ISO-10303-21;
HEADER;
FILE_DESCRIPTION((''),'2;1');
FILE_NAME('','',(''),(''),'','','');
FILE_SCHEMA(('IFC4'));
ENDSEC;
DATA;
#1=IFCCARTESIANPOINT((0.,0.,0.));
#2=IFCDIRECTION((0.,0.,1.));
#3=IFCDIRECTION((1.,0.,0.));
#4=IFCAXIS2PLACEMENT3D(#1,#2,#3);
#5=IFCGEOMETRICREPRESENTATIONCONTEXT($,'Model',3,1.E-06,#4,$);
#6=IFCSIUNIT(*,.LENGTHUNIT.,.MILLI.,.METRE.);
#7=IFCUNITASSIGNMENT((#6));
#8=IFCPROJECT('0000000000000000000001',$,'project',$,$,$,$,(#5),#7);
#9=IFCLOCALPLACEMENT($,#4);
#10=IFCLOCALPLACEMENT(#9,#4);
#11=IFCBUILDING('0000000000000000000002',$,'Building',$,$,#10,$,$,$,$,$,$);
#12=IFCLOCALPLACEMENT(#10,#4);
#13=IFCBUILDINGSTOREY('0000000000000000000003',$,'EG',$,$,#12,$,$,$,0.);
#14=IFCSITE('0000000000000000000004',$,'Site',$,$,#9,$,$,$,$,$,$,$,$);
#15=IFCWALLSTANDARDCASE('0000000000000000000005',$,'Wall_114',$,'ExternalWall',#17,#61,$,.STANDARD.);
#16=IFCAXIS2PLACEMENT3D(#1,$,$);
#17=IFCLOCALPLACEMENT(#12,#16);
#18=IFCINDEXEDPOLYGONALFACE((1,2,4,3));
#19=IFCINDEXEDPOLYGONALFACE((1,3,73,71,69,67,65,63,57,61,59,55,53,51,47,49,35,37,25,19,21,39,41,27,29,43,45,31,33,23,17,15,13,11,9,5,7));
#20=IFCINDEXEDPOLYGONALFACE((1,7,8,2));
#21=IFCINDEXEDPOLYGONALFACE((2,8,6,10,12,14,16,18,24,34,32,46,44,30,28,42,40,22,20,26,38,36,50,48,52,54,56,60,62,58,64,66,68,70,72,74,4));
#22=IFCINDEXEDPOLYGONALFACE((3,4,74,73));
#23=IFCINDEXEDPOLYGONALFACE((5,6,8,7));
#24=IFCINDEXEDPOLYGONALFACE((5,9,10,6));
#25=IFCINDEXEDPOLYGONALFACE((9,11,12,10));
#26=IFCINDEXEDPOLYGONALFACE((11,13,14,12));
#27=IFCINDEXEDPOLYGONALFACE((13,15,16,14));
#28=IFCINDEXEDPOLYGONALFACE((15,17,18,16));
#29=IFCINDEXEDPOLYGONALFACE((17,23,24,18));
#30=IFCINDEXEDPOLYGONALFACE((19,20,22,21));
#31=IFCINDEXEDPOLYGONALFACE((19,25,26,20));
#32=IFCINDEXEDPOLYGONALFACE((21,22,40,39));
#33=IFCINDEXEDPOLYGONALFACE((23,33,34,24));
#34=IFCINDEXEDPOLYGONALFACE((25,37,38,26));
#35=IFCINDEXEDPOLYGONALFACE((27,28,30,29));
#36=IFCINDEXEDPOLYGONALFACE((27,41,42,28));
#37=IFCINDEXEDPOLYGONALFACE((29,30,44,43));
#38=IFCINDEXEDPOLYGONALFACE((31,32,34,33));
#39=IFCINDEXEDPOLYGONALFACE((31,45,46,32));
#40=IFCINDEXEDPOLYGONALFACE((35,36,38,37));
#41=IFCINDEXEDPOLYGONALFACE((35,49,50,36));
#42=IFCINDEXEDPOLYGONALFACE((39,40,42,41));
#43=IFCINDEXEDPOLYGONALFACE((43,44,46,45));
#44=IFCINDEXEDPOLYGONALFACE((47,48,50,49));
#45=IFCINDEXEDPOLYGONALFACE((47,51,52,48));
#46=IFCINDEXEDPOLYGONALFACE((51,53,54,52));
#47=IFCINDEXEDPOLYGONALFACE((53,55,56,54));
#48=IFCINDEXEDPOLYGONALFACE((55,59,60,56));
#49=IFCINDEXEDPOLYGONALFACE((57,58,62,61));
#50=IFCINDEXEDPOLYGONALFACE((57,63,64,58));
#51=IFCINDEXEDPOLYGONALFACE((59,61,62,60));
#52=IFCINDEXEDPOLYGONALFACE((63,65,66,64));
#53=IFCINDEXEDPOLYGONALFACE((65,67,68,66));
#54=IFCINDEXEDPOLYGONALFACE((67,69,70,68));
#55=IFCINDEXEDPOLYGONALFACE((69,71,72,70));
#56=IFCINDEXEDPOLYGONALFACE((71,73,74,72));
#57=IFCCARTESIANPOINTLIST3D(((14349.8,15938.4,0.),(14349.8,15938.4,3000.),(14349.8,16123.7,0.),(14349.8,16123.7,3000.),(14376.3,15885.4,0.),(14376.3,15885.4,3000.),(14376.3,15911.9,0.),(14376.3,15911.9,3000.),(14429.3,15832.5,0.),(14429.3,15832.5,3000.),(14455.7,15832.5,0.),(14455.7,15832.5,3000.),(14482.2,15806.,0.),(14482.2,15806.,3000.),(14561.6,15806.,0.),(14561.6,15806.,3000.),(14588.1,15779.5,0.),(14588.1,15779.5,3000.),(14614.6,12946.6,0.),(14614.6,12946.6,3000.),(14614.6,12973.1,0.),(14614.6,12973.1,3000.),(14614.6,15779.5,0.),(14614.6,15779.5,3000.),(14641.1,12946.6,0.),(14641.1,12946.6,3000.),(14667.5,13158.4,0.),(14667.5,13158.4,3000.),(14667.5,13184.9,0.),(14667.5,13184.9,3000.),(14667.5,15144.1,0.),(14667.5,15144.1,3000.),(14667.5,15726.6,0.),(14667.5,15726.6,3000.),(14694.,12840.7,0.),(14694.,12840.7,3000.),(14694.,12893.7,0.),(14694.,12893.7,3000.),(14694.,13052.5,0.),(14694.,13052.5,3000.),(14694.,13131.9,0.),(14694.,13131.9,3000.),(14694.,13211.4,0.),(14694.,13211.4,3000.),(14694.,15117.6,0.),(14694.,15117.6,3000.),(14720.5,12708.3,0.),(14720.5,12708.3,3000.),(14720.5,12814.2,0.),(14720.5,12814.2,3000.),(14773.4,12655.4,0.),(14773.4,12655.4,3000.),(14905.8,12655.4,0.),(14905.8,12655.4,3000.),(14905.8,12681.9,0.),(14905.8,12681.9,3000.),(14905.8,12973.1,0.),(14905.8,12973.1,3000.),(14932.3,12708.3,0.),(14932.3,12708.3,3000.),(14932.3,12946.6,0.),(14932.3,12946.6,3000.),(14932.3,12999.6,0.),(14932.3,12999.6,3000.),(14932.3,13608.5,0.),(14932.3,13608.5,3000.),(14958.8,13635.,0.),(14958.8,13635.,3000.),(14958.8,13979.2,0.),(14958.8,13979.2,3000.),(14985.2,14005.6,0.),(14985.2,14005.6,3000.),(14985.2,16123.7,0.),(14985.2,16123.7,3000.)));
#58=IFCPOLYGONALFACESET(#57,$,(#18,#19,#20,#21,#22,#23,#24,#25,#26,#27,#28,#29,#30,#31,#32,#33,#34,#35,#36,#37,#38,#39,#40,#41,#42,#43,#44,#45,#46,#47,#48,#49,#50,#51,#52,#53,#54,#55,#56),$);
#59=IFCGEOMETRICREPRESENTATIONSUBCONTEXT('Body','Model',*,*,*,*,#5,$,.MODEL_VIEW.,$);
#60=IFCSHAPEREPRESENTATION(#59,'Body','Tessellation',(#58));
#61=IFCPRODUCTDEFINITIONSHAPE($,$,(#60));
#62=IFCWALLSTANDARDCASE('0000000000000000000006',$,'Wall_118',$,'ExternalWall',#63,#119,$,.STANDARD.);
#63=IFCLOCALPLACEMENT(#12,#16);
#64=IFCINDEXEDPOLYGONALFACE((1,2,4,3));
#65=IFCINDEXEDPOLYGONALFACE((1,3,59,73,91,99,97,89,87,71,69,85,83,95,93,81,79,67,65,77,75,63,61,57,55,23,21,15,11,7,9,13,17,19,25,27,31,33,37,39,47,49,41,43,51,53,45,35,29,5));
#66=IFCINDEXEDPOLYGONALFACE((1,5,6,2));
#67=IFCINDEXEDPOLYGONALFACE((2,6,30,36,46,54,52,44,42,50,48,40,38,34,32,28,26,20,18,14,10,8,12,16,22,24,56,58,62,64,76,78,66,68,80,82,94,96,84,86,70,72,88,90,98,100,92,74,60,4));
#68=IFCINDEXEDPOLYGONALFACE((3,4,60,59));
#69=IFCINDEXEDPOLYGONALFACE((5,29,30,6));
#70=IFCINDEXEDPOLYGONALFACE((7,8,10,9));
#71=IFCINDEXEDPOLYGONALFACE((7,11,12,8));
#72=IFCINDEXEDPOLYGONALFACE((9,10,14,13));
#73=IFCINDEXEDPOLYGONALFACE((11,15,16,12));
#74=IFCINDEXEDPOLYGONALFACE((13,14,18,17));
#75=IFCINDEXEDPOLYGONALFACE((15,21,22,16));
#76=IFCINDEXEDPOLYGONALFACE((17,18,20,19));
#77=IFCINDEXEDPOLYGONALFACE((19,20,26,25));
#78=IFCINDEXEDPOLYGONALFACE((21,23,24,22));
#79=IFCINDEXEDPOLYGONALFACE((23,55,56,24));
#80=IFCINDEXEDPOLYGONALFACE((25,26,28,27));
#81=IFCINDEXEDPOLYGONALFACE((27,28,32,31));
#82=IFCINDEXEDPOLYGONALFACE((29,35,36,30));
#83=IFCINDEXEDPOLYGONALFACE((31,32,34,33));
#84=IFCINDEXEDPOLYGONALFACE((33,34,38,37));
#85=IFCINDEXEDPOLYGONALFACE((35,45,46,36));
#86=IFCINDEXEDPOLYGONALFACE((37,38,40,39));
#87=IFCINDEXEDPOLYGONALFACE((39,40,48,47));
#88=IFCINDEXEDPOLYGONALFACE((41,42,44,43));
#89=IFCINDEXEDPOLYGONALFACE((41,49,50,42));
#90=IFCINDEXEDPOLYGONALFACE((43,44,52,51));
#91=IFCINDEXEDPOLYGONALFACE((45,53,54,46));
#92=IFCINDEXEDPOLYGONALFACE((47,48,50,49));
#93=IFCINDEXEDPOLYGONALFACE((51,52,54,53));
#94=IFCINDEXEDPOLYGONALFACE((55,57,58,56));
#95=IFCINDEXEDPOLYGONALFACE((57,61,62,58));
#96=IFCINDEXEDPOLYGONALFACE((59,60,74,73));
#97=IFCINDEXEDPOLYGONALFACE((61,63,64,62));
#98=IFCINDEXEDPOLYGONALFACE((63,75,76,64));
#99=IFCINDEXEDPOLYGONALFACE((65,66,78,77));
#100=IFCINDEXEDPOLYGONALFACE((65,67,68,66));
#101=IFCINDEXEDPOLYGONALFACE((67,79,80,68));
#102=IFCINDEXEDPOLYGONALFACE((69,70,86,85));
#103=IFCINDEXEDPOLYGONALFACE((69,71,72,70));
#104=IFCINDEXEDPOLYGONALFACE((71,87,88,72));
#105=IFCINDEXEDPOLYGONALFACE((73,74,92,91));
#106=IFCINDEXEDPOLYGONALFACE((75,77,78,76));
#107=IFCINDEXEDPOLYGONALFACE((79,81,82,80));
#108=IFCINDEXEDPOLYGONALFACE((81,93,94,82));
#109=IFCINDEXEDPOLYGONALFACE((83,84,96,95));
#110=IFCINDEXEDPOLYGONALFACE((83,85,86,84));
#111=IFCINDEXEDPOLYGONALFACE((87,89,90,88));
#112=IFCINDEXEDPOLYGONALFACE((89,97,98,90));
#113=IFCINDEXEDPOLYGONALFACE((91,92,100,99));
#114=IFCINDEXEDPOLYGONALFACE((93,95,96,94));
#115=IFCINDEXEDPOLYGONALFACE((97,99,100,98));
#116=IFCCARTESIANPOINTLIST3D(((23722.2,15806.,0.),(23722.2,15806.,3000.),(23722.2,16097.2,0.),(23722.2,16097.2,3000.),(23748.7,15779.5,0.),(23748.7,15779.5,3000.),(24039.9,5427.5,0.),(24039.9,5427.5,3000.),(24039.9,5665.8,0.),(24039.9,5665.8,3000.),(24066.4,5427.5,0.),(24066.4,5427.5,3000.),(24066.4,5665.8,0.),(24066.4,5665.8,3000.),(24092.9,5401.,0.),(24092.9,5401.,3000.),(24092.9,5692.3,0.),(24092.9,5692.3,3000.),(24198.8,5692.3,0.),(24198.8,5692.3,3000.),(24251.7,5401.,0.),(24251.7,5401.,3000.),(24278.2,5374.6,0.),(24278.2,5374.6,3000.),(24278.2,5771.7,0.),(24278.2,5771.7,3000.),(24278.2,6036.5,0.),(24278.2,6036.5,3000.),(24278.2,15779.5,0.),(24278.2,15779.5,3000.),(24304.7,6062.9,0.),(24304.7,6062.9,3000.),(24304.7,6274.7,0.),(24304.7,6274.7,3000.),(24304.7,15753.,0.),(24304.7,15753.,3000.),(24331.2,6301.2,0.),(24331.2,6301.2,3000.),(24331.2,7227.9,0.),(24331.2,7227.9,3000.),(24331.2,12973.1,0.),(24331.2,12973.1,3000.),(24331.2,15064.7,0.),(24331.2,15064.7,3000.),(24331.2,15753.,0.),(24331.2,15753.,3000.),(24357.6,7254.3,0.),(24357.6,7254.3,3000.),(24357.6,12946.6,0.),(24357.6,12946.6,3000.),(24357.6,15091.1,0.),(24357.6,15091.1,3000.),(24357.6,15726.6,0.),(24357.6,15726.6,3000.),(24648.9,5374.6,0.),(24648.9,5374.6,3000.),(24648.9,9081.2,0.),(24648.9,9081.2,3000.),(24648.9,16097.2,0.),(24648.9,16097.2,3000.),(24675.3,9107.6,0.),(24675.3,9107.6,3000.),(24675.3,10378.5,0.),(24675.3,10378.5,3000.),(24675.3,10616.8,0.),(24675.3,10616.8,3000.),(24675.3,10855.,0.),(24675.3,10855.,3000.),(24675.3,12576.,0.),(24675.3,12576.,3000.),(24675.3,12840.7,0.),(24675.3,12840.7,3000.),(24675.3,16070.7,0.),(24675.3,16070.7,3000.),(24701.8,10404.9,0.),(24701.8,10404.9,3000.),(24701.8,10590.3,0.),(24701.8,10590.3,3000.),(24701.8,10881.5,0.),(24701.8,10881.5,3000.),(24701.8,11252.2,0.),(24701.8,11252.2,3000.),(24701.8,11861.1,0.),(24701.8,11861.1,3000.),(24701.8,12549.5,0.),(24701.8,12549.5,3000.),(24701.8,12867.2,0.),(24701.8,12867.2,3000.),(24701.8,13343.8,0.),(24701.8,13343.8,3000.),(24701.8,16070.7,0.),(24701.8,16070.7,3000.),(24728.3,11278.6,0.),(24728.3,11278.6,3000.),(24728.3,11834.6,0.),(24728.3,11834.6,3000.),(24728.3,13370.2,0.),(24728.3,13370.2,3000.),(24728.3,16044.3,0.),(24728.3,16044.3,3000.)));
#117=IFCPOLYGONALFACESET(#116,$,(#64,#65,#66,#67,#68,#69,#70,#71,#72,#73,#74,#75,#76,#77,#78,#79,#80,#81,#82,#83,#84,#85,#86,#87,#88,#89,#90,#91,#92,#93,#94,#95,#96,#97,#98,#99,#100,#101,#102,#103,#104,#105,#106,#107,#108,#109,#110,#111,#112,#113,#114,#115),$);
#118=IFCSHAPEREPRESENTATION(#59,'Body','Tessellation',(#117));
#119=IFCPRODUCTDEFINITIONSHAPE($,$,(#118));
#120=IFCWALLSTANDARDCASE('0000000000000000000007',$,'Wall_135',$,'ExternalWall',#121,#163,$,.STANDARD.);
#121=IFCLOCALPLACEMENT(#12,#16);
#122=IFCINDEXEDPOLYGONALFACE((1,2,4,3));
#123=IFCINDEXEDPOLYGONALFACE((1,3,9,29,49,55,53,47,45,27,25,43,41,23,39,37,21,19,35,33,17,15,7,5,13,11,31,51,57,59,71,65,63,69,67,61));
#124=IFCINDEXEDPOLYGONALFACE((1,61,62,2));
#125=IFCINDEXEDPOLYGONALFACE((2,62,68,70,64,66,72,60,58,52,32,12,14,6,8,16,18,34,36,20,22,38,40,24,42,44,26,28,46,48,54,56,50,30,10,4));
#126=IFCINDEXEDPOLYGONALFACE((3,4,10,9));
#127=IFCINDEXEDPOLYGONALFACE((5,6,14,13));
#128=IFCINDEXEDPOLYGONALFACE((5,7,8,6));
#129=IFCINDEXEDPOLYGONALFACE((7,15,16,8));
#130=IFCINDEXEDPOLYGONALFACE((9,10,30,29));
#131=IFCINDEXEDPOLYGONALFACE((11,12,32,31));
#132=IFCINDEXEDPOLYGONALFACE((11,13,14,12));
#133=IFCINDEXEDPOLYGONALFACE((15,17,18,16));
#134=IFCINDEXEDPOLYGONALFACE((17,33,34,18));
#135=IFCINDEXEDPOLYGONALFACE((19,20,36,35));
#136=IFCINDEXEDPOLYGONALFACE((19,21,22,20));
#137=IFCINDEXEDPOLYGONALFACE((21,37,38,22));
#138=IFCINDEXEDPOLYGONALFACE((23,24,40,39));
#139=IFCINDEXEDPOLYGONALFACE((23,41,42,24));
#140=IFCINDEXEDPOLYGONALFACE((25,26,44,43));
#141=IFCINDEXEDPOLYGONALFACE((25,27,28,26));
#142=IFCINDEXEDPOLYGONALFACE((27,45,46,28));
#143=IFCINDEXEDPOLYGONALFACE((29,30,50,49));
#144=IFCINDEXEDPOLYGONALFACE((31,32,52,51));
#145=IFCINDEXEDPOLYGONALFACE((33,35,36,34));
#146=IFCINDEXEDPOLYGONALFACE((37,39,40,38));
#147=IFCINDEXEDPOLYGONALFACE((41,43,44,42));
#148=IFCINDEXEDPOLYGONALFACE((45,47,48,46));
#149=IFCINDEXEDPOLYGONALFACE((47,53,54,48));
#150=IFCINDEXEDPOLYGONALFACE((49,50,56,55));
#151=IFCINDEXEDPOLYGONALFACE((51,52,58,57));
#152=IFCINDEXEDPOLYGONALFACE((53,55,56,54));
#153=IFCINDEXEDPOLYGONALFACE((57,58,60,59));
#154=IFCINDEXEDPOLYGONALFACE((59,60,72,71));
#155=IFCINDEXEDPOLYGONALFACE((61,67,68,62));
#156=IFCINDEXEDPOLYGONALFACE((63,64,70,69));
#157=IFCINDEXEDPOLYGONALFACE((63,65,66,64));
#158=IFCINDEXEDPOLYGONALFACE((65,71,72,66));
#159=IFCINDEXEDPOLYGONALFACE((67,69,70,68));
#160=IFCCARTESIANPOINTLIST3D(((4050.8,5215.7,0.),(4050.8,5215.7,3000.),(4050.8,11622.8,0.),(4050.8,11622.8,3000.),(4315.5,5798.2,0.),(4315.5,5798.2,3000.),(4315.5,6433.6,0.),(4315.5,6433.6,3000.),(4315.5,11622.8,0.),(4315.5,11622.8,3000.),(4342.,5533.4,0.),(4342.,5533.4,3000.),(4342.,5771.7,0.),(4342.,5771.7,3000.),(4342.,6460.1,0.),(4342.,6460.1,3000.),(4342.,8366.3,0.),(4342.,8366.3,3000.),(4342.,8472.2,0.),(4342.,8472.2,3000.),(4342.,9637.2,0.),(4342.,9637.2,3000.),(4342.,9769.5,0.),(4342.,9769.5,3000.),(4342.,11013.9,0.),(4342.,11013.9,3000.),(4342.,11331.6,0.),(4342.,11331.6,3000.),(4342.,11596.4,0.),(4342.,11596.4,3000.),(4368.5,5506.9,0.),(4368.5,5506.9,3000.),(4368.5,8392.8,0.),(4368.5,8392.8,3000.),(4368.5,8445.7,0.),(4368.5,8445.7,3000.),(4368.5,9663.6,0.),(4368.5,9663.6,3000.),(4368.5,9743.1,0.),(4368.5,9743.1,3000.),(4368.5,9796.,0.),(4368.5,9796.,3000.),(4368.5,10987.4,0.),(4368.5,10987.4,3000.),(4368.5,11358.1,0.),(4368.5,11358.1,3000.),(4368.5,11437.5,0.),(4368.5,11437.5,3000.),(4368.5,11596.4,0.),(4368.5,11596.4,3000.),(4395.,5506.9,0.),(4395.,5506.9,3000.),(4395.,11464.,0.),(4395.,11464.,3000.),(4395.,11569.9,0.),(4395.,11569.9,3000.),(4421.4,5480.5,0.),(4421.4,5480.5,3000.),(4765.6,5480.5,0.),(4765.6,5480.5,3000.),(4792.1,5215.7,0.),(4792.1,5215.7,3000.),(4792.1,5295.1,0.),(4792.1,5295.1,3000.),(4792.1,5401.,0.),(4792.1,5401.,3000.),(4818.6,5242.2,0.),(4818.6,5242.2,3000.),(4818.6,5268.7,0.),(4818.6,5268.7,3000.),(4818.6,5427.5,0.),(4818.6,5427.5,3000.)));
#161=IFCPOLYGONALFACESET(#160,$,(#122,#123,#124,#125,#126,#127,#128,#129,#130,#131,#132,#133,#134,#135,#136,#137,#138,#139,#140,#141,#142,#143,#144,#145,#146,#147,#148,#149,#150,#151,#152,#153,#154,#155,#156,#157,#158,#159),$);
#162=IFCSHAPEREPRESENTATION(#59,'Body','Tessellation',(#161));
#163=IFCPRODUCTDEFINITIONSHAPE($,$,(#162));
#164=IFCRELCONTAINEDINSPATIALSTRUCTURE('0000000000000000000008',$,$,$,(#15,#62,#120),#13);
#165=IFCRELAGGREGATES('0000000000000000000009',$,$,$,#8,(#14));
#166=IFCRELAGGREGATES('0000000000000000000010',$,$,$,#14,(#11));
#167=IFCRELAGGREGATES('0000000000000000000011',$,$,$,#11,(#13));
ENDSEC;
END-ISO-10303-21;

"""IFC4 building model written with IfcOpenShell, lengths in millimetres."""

from ifc_helpers import new_model, si_unit, frame, origin_with_axes, place, context, subcontext, project, spatial, polyline, outline, extrude, element, save


model = new_model("IFC4")

# Units and contexts
model_context = context("Model", 3, precision=1e-06, world=origin_with_axes())
body_context = subcontext(model_context, "Body", "Model", "MODEL_VIEW")
ifc_project = project(units=[si_unit("LENGTHUNIT", "METRE", prefix="MILLI")], contexts=[model_context])

# Site, building, storey
site_placement = place(None, origin_with_axes())
site = spatial("IfcSite", under=ifc_project, at=site_placement, Name="Site")
building_placement = place(site_placement, origin_with_axes())
building = spatial("IfcBuilding", under=site, at=building_placement, Name="Building")
storey_placement = place(building_placement, origin_with_axes())
storey = spatial("IfcBuildingStorey", under=building, at=storey_placement, Name="EG", Elevation=0.0)

# Walls
for number, where, z_axis, x_axis, name in (
    (1, (0.0, 0.0, 0.0), (0.0, 0.0, 1.0), (1.0, 0.0, 0.0), "Wall_114"),
):
    element("IfcWallStandardCase", number, at=place(storey_placement, frame(where, z_axis=z_axis, x_axis=x_axis)), inside=storey, Name=name, ObjectType="ExternalWall", PredefinedType="STANDARD", context=body_context, shape_type="SweptSolid", body=[
        extrude(outline(polyline([(14773.4, 12655.4, 0.0), (14720.5, 12708.3, 0.0), (14720.5, 12814.2, 0.0), (14694.0, 12840.7, 0.0), (14694.0, 12893.7, 0.0), (14641.1, 12946.6, 0.0), (14614.6, 12946.6, 0.0), (14614.6, 12973.1, 0.0), (14694.0, 13052.5, 0.0), (14694.0, 13131.9, 0.0), (14667.5, 13158.4, 0.0), (14667.5, 13184.9, 0.0), (14694.0, 13211.4, 0.0), (14694.0, 15117.6, 0.0), (14667.5, 15144.1, 0.0), (14667.5, 15726.6, 0.0), (14614.6, 15779.5, 0.0), (14588.1, 15779.5, 0.0), (14561.6, 15806.0, 0.0), (14482.2, 15806.0, 0.0), (14455.7, 15832.5, 0.0), (14429.3, 15832.5, 0.0), (14376.3, 15885.4, 0.0), (14376.3, 15911.9, 0.0), (14349.8, 15938.4, 0.0), (14349.8, 16123.7, 0.0), (14985.2, 16123.7, 0.0), (14985.2, 14005.6, 0.0), (14958.8, 13979.2, 0.0), (14958.8, 13635.0, 0.0), (14932.3, 13608.5, 0.0), (14932.3, 12999.6, 0.0), (14905.8, 12973.1, 0.0), (14932.3, 12946.6, 0.0), (14932.3, 12708.3, 0.0), (14905.8, 12681.9, 0.0), (14905.8, 12655.4, 0.0), (14773.4, 12655.4, 0.0)])), origin_with_axes(), (0.0, 0.0, 1.0), 3000.0),
    ])
wall_1_placement = place(storey_placement, origin_with_axes())
element("IfcWallStandardCase", 2, at=wall_1_placement, inside=storey, Name="Wall_118", ObjectType="ExternalWall", PredefinedType="STANDARD", context=body_context, shape_type="SweptSolid", body=[
    extrude(outline(polyline([(24278.2, 5374.6, 0.0), (24251.7, 5401.0, 0.0), (24092.9, 5401.0, 0.0), (24066.4, 5427.5, 0.0), (24039.9, 5427.5, 0.0), (24039.9, 5665.8, 0.0), (24066.4, 5665.8, 0.0), (24092.9, 5692.3, 0.0), (24198.8, 5692.3, 0.0), (24278.2, 5771.7, 0.0), (24278.2, 6036.5, 0.0), (24304.7, 6062.9, 0.0), (24304.7, 6274.7, 0.0), (24331.2, 6301.2, 0.0), (24331.2, 7227.9, 0.0), (24357.6, 7254.3, 0.0), (24357.6, 12946.6, 0.0), (24331.2, 12973.1, 0.0), (24331.2, 15064.7, 0.0), (24357.6, 15091.1, 0.0), (24357.6, 15726.6, 0.0), (24331.2, 15753.0, 0.0), (24304.7, 15753.0, 0.0), (24278.2, 15779.5, 0.0), (23748.7, 15779.5, 0.0), (23722.2, 15806.0, 0.0), (23722.2, 16097.2, 0.0), (24648.9, 16097.2, 0.0), (24675.3, 16070.7, 0.0), (24701.8, 16070.7, 0.0), (24728.3, 16044.3, 0.0), (24728.3, 13370.2, 0.0), (24701.8, 13343.8, 0.0), (24701.8, 12867.2, 0.0), (24675.3, 12840.7, 0.0), (24675.3, 12576.0, 0.0), (24701.8, 12549.5, 0.0), (24701.8, 11861.1, 0.0), (24728.3, 11834.6, 0.0), (24728.3, 11278.6, 0.0), (24701.8, 11252.2, 0.0), (24701.8, 10881.5, 0.0), (24675.3, 10855.0, 0.0), (24675.3, 10616.8, 0.0), (24701.8, 10590.3, 0.0), (24701.8, 10404.9, 0.0), (24675.3, 10378.5, 0.0), (24675.3, 9107.6, 0.0), (24648.9, 9081.2, 0.0), (24648.9, 5374.6, 0.0), (24278.2, 5374.6, 0.0)])), origin_with_axes(), (0.0, 0.0, 1.0), 3000.0),
])
for number, where, z_axis, x_axis, name in (
    (3, (0.0, 0.0, 0.0), (0.0, 0.0, 1.0), (1.0, 0.0, 0.0), "Wall_135"),
):
    element("IfcWallStandardCase", number, at=place(storey_placement, frame(where, z_axis=z_axis, x_axis=x_axis)), inside=storey, Name=name, ObjectType="ExternalWall", PredefinedType="STANDARD", context=body_context, shape_type="SweptSolid", body=[
        extrude(outline(polyline([(4050.8, 5215.7, 0.0), (4050.8, 11622.8, 0.0), (4315.5, 11622.8, 0.0), (4342.0, 11596.4, 0.0), (4368.5, 11596.4, 0.0), (4395.0, 11569.9, 0.0), (4395.0, 11464.0, 0.0), (4368.5, 11437.5, 0.0), (4368.5, 11358.1, 0.0), (4342.0, 11331.6, 0.0), (4342.0, 11013.9, 0.0), (4368.5, 10987.4, 0.0), (4368.5, 9796.0, 0.0), (4342.0, 9769.5, 0.0), (4368.5, 9743.1, 0.0), (4368.5, 9663.6, 0.0), (4342.0, 9637.2, 0.0), (4342.0, 8472.2, 0.0), (4368.5, 8445.7, 0.0), (4368.5, 8392.8, 0.0), (4342.0, 8366.3, 0.0), (4342.0, 6460.1, 0.0), (4315.5, 6433.6, 0.0), (4315.5, 5798.2, 0.0), (4342.0, 5771.7, 0.0), (4342.0, 5533.4, 0.0), (4368.5, 5506.9, 0.0), (4395.0, 5506.9, 0.0), (4421.4, 5480.5, 0.0), (4765.6, 5480.5, 0.0), (4818.6, 5427.5, 0.0), (4792.1, 5401.0, 0.0), (4792.1, 5295.1, 0.0), (4818.6, 5268.7, 0.0), (4818.6, 5242.2, 0.0), (4792.1, 5215.7, 0.0), (4050.8, 5215.7, 0.0)])), origin_with_axes(), (0.0, 0.0, 1.0), 3000.0),
    ])

save(model, "model.ifc")
